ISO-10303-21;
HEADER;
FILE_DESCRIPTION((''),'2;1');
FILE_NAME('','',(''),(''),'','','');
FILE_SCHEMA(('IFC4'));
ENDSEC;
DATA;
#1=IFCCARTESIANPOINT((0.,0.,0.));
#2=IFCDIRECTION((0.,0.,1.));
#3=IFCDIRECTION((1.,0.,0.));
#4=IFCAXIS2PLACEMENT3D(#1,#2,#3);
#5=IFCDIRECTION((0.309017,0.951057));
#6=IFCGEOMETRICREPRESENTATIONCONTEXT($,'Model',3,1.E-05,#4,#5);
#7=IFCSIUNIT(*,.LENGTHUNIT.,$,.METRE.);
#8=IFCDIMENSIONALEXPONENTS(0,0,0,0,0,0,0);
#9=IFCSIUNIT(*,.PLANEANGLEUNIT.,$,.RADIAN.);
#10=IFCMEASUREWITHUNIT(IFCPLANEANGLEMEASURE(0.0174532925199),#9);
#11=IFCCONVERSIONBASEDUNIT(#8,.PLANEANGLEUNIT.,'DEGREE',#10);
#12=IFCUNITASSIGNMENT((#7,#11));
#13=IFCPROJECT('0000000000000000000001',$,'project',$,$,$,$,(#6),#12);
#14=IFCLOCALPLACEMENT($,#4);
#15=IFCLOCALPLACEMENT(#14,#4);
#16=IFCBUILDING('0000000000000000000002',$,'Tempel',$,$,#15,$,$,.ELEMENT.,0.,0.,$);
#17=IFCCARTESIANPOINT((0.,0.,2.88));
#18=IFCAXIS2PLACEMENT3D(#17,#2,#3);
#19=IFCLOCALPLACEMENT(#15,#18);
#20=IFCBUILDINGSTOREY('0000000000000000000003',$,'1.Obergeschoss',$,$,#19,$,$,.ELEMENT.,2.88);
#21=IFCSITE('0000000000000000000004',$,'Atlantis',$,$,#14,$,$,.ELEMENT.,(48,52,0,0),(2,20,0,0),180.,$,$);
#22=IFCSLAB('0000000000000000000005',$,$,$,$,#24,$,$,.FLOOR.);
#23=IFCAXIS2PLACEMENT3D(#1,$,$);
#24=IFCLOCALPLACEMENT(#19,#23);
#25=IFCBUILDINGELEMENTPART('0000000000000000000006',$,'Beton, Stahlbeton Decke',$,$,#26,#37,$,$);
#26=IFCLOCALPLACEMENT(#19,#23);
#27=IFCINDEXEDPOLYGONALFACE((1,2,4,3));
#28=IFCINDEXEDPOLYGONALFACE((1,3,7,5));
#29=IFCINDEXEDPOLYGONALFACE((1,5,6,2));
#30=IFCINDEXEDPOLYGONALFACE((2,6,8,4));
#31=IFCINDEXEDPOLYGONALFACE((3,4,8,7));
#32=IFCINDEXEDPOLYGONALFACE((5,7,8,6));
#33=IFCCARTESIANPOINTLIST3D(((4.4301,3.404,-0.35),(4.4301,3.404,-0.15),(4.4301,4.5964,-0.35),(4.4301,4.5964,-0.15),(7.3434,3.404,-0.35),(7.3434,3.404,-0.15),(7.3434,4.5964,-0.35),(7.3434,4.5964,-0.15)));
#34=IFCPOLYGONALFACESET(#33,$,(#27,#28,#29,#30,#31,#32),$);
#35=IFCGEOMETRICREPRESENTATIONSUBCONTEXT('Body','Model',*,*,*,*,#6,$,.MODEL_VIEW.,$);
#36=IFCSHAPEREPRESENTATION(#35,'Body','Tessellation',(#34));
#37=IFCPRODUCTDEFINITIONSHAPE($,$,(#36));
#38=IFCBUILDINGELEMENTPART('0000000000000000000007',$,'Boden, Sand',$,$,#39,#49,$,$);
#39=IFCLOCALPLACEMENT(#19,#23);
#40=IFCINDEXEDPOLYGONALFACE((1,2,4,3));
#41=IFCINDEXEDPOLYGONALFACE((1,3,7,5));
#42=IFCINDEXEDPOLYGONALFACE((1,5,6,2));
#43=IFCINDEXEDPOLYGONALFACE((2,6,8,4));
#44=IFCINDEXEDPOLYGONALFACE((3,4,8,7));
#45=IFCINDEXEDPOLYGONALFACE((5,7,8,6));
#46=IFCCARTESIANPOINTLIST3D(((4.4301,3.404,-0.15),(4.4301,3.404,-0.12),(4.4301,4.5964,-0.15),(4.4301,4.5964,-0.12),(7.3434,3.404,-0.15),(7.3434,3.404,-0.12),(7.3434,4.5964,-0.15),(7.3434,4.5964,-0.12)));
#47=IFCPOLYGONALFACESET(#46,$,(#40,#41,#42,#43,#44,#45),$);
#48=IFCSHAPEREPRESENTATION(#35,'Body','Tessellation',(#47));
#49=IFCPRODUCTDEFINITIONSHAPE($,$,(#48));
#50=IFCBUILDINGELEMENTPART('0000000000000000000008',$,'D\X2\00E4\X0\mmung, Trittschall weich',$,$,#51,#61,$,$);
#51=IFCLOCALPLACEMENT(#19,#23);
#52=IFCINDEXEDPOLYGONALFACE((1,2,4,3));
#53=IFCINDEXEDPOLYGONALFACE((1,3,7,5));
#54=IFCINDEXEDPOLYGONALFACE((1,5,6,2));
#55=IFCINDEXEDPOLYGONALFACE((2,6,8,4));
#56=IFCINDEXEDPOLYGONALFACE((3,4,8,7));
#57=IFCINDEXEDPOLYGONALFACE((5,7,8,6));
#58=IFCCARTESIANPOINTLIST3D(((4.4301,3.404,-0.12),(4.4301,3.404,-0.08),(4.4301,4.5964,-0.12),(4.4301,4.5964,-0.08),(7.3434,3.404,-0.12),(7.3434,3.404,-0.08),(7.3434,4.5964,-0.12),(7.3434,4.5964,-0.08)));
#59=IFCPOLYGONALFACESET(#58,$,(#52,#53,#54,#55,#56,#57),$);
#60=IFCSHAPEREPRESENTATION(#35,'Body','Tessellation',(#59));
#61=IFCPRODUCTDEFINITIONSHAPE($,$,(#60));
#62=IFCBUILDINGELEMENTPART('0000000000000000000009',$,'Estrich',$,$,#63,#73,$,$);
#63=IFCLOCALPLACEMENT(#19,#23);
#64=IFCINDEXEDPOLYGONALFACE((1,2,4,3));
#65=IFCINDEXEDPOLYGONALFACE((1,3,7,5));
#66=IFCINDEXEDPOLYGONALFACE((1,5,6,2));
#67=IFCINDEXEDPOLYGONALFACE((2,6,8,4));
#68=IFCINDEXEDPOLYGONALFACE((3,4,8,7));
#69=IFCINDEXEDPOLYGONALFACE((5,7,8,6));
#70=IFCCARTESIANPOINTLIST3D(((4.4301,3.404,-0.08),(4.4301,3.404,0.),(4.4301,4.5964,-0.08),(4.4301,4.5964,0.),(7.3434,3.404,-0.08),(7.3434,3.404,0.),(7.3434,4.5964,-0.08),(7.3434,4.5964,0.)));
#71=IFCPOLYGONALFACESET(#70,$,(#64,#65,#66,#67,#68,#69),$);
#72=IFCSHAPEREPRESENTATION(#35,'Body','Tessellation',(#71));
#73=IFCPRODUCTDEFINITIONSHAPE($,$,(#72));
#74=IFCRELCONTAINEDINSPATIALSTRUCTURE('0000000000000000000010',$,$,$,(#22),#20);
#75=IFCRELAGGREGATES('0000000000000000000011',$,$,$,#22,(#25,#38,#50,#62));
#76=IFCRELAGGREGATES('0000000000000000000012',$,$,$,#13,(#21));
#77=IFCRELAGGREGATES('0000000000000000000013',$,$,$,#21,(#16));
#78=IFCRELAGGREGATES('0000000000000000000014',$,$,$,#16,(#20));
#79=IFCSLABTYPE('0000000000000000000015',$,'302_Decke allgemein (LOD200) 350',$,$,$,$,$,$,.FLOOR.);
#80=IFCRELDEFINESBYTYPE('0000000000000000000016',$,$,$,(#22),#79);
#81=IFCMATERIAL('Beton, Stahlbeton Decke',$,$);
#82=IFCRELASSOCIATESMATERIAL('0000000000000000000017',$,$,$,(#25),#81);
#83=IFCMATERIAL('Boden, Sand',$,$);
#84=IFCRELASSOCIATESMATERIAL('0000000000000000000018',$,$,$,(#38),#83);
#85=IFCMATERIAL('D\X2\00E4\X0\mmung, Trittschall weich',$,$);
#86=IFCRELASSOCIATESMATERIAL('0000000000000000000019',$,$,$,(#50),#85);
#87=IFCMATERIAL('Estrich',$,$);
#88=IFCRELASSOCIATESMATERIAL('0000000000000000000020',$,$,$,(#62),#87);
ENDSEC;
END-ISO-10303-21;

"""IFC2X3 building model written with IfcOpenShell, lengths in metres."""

from ifc_helpers import new_model, entity, si_unit, converted_unit, direction, frame, origin_with_axes, place, context, subcontext, project, spatial, polyline, outline, extrude, material, type_object, element, aggregate, save


model = new_model("IFC2X3")

# Units and contexts
model_context = context("Model", 3, precision=1e-05, world=origin_with_axes(), true_north=direction((0.309017, 0.951057)))
body_context = subcontext(model_context, "Body", "Model", "MODEL_VIEW")
ifc_project = project(units=[si_unit("LENGTHUNIT", "METRE"), converted_unit("PLANEANGLEUNIT", "DEGREE", entity("IfcPlaneAngleMeasure", 0.0174532925199), si_unit("PLANEANGLEUNIT", "RADIAN"), dimensions=[0, 0, 0, 0, 0, 0, 0])], contexts=[model_context])

# Site, building, storey
site_placement = place(None, origin_with_axes())
site = spatial("IfcSite", under=ifc_project, at=site_placement, Name="Atlantis", CompositionType="ELEMENT", RefLatitude=(48, 52, 0, 0), RefLongitude=(2, 20, 0, 0), RefElevation=180.0)
building_placement = place(site_placement, origin_with_axes())
building = spatial("IfcBuilding", under=site, at=building_placement, Name="Tempel", CompositionType="ELEMENT", ElevationOfRefHeight=0.0, ElevationOfTerrain=0.0)
storey_placement = place(building_placement, frame((0.0, 0.0, 2.88), z_axis=(0.0, 0.0, 1.0), x_axis=(1.0, 0.0, 0.0)))
storey = spatial("IfcBuildingStorey", under=building, at=storey_placement, Name="1.Obergeschoss", CompositionType="ELEMENT", Elevation=2.88)

# Slab, building element parts
slab_type = type_object("IfcSlabType", Name="302_Decke allgemein (LOD200) 350", PredefinedType="FLOOR")
slab_placement = place(storey_placement, frame((4.4301, 3.404, -0.15), z_axis=(0.0, 0.0, 1.0), x_axis=(1.0, 0.0, 0.0)))
slab = element("IfcSlab", 1, at=slab_placement, inside=storey, type_object=slab_type, PredefinedType="FLOOR")
ifc_material_1 = material(Name="Beton, Stahlbeton Decke")
building_element_part_1_placement = place(slab_placement, origin_with_axes())
building_element_part_1 = element("IfcBuildingElementPart", 2, at=building_element_part_1_placement, material=ifc_material_1, Name="Beton, Stahlbeton Decke", context=body_context, shape_type="SweptSolid", body=[
    extrude(outline(polyline([(0.0, 0.0), (2.9133, 0.0), (2.9133, 1.1924), (0.0, 1.1924), (0.0, 0.0)])), frame((0.0, 0.0, -0.2), z_axis=(0.0, 0.0, 1.0), x_axis=(1.0, 0.0, 0.0)), (0.0, 0.0, 1.0), 0.2),
])
ifc_material_2 = material(Name="Boden, Sand")
building_element_part_2_placement = place(slab_placement, origin_with_axes())
building_element_part_2 = element("IfcBuildingElementPart", 3, at=building_element_part_2_placement, material=ifc_material_2, Name="Boden, Sand", context=body_context, shape_type="SweptSolid", body=[
    extrude(outline(polyline([(0.0, 0.0), (2.9133, 0.0), (2.9133, 1.1924), (0.0, 1.1924), (0.0, 0.0)])), origin_with_axes(), (0.0, 0.0, 1.0), 0.03),
])
ifc_material_3 = material(Name="Dämmung, Trittschall weich")
building_element_part_3_placement = place(slab_placement, origin_with_axes())
building_element_part_3 = element("IfcBuildingElementPart", 4, at=building_element_part_3_placement, material=ifc_material_3, Name="Dämmung, Trittschall weich", context=body_context, shape_type="SweptSolid", body=[
    extrude(outline(polyline([(0.0, 0.0), (2.9133, 0.0), (2.9133, 1.1924), (0.0, 1.1924), (0.0, 0.0)])), frame((0.0, 0.0, 0.03), z_axis=(0.0, 0.0, 1.0), x_axis=(1.0, 0.0, 0.0)), (0.0, 0.0, 1.0), 0.04),
])
ifc_material_4 = material(Name="Estrich")
building_element_part_4_placement = place(slab_placement, origin_with_axes())
building_element_part_4 = element("IfcBuildingElementPart", 5, at=building_element_part_4_placement, material=ifc_material_4, Name="Estrich", context=body_context, shape_type="SweptSolid", body=[
    extrude(outline(polyline([(0.0, 0.0), (2.9133, 0.0), (2.9133, 1.1924), (0.0, 1.1924), (0.0, 0.0)])), frame((0.0, 0.0, 0.07), z_axis=(0.0, 0.0, 1.0), x_axis=(1.0, 0.0, 0.0)), (0.0, 0.0, 1.0), 0.08),
])
aggregate(slab, [building_element_part_1, building_element_part_2, building_element_part_3, building_element_part_4])

save(model, "model.ifc")
